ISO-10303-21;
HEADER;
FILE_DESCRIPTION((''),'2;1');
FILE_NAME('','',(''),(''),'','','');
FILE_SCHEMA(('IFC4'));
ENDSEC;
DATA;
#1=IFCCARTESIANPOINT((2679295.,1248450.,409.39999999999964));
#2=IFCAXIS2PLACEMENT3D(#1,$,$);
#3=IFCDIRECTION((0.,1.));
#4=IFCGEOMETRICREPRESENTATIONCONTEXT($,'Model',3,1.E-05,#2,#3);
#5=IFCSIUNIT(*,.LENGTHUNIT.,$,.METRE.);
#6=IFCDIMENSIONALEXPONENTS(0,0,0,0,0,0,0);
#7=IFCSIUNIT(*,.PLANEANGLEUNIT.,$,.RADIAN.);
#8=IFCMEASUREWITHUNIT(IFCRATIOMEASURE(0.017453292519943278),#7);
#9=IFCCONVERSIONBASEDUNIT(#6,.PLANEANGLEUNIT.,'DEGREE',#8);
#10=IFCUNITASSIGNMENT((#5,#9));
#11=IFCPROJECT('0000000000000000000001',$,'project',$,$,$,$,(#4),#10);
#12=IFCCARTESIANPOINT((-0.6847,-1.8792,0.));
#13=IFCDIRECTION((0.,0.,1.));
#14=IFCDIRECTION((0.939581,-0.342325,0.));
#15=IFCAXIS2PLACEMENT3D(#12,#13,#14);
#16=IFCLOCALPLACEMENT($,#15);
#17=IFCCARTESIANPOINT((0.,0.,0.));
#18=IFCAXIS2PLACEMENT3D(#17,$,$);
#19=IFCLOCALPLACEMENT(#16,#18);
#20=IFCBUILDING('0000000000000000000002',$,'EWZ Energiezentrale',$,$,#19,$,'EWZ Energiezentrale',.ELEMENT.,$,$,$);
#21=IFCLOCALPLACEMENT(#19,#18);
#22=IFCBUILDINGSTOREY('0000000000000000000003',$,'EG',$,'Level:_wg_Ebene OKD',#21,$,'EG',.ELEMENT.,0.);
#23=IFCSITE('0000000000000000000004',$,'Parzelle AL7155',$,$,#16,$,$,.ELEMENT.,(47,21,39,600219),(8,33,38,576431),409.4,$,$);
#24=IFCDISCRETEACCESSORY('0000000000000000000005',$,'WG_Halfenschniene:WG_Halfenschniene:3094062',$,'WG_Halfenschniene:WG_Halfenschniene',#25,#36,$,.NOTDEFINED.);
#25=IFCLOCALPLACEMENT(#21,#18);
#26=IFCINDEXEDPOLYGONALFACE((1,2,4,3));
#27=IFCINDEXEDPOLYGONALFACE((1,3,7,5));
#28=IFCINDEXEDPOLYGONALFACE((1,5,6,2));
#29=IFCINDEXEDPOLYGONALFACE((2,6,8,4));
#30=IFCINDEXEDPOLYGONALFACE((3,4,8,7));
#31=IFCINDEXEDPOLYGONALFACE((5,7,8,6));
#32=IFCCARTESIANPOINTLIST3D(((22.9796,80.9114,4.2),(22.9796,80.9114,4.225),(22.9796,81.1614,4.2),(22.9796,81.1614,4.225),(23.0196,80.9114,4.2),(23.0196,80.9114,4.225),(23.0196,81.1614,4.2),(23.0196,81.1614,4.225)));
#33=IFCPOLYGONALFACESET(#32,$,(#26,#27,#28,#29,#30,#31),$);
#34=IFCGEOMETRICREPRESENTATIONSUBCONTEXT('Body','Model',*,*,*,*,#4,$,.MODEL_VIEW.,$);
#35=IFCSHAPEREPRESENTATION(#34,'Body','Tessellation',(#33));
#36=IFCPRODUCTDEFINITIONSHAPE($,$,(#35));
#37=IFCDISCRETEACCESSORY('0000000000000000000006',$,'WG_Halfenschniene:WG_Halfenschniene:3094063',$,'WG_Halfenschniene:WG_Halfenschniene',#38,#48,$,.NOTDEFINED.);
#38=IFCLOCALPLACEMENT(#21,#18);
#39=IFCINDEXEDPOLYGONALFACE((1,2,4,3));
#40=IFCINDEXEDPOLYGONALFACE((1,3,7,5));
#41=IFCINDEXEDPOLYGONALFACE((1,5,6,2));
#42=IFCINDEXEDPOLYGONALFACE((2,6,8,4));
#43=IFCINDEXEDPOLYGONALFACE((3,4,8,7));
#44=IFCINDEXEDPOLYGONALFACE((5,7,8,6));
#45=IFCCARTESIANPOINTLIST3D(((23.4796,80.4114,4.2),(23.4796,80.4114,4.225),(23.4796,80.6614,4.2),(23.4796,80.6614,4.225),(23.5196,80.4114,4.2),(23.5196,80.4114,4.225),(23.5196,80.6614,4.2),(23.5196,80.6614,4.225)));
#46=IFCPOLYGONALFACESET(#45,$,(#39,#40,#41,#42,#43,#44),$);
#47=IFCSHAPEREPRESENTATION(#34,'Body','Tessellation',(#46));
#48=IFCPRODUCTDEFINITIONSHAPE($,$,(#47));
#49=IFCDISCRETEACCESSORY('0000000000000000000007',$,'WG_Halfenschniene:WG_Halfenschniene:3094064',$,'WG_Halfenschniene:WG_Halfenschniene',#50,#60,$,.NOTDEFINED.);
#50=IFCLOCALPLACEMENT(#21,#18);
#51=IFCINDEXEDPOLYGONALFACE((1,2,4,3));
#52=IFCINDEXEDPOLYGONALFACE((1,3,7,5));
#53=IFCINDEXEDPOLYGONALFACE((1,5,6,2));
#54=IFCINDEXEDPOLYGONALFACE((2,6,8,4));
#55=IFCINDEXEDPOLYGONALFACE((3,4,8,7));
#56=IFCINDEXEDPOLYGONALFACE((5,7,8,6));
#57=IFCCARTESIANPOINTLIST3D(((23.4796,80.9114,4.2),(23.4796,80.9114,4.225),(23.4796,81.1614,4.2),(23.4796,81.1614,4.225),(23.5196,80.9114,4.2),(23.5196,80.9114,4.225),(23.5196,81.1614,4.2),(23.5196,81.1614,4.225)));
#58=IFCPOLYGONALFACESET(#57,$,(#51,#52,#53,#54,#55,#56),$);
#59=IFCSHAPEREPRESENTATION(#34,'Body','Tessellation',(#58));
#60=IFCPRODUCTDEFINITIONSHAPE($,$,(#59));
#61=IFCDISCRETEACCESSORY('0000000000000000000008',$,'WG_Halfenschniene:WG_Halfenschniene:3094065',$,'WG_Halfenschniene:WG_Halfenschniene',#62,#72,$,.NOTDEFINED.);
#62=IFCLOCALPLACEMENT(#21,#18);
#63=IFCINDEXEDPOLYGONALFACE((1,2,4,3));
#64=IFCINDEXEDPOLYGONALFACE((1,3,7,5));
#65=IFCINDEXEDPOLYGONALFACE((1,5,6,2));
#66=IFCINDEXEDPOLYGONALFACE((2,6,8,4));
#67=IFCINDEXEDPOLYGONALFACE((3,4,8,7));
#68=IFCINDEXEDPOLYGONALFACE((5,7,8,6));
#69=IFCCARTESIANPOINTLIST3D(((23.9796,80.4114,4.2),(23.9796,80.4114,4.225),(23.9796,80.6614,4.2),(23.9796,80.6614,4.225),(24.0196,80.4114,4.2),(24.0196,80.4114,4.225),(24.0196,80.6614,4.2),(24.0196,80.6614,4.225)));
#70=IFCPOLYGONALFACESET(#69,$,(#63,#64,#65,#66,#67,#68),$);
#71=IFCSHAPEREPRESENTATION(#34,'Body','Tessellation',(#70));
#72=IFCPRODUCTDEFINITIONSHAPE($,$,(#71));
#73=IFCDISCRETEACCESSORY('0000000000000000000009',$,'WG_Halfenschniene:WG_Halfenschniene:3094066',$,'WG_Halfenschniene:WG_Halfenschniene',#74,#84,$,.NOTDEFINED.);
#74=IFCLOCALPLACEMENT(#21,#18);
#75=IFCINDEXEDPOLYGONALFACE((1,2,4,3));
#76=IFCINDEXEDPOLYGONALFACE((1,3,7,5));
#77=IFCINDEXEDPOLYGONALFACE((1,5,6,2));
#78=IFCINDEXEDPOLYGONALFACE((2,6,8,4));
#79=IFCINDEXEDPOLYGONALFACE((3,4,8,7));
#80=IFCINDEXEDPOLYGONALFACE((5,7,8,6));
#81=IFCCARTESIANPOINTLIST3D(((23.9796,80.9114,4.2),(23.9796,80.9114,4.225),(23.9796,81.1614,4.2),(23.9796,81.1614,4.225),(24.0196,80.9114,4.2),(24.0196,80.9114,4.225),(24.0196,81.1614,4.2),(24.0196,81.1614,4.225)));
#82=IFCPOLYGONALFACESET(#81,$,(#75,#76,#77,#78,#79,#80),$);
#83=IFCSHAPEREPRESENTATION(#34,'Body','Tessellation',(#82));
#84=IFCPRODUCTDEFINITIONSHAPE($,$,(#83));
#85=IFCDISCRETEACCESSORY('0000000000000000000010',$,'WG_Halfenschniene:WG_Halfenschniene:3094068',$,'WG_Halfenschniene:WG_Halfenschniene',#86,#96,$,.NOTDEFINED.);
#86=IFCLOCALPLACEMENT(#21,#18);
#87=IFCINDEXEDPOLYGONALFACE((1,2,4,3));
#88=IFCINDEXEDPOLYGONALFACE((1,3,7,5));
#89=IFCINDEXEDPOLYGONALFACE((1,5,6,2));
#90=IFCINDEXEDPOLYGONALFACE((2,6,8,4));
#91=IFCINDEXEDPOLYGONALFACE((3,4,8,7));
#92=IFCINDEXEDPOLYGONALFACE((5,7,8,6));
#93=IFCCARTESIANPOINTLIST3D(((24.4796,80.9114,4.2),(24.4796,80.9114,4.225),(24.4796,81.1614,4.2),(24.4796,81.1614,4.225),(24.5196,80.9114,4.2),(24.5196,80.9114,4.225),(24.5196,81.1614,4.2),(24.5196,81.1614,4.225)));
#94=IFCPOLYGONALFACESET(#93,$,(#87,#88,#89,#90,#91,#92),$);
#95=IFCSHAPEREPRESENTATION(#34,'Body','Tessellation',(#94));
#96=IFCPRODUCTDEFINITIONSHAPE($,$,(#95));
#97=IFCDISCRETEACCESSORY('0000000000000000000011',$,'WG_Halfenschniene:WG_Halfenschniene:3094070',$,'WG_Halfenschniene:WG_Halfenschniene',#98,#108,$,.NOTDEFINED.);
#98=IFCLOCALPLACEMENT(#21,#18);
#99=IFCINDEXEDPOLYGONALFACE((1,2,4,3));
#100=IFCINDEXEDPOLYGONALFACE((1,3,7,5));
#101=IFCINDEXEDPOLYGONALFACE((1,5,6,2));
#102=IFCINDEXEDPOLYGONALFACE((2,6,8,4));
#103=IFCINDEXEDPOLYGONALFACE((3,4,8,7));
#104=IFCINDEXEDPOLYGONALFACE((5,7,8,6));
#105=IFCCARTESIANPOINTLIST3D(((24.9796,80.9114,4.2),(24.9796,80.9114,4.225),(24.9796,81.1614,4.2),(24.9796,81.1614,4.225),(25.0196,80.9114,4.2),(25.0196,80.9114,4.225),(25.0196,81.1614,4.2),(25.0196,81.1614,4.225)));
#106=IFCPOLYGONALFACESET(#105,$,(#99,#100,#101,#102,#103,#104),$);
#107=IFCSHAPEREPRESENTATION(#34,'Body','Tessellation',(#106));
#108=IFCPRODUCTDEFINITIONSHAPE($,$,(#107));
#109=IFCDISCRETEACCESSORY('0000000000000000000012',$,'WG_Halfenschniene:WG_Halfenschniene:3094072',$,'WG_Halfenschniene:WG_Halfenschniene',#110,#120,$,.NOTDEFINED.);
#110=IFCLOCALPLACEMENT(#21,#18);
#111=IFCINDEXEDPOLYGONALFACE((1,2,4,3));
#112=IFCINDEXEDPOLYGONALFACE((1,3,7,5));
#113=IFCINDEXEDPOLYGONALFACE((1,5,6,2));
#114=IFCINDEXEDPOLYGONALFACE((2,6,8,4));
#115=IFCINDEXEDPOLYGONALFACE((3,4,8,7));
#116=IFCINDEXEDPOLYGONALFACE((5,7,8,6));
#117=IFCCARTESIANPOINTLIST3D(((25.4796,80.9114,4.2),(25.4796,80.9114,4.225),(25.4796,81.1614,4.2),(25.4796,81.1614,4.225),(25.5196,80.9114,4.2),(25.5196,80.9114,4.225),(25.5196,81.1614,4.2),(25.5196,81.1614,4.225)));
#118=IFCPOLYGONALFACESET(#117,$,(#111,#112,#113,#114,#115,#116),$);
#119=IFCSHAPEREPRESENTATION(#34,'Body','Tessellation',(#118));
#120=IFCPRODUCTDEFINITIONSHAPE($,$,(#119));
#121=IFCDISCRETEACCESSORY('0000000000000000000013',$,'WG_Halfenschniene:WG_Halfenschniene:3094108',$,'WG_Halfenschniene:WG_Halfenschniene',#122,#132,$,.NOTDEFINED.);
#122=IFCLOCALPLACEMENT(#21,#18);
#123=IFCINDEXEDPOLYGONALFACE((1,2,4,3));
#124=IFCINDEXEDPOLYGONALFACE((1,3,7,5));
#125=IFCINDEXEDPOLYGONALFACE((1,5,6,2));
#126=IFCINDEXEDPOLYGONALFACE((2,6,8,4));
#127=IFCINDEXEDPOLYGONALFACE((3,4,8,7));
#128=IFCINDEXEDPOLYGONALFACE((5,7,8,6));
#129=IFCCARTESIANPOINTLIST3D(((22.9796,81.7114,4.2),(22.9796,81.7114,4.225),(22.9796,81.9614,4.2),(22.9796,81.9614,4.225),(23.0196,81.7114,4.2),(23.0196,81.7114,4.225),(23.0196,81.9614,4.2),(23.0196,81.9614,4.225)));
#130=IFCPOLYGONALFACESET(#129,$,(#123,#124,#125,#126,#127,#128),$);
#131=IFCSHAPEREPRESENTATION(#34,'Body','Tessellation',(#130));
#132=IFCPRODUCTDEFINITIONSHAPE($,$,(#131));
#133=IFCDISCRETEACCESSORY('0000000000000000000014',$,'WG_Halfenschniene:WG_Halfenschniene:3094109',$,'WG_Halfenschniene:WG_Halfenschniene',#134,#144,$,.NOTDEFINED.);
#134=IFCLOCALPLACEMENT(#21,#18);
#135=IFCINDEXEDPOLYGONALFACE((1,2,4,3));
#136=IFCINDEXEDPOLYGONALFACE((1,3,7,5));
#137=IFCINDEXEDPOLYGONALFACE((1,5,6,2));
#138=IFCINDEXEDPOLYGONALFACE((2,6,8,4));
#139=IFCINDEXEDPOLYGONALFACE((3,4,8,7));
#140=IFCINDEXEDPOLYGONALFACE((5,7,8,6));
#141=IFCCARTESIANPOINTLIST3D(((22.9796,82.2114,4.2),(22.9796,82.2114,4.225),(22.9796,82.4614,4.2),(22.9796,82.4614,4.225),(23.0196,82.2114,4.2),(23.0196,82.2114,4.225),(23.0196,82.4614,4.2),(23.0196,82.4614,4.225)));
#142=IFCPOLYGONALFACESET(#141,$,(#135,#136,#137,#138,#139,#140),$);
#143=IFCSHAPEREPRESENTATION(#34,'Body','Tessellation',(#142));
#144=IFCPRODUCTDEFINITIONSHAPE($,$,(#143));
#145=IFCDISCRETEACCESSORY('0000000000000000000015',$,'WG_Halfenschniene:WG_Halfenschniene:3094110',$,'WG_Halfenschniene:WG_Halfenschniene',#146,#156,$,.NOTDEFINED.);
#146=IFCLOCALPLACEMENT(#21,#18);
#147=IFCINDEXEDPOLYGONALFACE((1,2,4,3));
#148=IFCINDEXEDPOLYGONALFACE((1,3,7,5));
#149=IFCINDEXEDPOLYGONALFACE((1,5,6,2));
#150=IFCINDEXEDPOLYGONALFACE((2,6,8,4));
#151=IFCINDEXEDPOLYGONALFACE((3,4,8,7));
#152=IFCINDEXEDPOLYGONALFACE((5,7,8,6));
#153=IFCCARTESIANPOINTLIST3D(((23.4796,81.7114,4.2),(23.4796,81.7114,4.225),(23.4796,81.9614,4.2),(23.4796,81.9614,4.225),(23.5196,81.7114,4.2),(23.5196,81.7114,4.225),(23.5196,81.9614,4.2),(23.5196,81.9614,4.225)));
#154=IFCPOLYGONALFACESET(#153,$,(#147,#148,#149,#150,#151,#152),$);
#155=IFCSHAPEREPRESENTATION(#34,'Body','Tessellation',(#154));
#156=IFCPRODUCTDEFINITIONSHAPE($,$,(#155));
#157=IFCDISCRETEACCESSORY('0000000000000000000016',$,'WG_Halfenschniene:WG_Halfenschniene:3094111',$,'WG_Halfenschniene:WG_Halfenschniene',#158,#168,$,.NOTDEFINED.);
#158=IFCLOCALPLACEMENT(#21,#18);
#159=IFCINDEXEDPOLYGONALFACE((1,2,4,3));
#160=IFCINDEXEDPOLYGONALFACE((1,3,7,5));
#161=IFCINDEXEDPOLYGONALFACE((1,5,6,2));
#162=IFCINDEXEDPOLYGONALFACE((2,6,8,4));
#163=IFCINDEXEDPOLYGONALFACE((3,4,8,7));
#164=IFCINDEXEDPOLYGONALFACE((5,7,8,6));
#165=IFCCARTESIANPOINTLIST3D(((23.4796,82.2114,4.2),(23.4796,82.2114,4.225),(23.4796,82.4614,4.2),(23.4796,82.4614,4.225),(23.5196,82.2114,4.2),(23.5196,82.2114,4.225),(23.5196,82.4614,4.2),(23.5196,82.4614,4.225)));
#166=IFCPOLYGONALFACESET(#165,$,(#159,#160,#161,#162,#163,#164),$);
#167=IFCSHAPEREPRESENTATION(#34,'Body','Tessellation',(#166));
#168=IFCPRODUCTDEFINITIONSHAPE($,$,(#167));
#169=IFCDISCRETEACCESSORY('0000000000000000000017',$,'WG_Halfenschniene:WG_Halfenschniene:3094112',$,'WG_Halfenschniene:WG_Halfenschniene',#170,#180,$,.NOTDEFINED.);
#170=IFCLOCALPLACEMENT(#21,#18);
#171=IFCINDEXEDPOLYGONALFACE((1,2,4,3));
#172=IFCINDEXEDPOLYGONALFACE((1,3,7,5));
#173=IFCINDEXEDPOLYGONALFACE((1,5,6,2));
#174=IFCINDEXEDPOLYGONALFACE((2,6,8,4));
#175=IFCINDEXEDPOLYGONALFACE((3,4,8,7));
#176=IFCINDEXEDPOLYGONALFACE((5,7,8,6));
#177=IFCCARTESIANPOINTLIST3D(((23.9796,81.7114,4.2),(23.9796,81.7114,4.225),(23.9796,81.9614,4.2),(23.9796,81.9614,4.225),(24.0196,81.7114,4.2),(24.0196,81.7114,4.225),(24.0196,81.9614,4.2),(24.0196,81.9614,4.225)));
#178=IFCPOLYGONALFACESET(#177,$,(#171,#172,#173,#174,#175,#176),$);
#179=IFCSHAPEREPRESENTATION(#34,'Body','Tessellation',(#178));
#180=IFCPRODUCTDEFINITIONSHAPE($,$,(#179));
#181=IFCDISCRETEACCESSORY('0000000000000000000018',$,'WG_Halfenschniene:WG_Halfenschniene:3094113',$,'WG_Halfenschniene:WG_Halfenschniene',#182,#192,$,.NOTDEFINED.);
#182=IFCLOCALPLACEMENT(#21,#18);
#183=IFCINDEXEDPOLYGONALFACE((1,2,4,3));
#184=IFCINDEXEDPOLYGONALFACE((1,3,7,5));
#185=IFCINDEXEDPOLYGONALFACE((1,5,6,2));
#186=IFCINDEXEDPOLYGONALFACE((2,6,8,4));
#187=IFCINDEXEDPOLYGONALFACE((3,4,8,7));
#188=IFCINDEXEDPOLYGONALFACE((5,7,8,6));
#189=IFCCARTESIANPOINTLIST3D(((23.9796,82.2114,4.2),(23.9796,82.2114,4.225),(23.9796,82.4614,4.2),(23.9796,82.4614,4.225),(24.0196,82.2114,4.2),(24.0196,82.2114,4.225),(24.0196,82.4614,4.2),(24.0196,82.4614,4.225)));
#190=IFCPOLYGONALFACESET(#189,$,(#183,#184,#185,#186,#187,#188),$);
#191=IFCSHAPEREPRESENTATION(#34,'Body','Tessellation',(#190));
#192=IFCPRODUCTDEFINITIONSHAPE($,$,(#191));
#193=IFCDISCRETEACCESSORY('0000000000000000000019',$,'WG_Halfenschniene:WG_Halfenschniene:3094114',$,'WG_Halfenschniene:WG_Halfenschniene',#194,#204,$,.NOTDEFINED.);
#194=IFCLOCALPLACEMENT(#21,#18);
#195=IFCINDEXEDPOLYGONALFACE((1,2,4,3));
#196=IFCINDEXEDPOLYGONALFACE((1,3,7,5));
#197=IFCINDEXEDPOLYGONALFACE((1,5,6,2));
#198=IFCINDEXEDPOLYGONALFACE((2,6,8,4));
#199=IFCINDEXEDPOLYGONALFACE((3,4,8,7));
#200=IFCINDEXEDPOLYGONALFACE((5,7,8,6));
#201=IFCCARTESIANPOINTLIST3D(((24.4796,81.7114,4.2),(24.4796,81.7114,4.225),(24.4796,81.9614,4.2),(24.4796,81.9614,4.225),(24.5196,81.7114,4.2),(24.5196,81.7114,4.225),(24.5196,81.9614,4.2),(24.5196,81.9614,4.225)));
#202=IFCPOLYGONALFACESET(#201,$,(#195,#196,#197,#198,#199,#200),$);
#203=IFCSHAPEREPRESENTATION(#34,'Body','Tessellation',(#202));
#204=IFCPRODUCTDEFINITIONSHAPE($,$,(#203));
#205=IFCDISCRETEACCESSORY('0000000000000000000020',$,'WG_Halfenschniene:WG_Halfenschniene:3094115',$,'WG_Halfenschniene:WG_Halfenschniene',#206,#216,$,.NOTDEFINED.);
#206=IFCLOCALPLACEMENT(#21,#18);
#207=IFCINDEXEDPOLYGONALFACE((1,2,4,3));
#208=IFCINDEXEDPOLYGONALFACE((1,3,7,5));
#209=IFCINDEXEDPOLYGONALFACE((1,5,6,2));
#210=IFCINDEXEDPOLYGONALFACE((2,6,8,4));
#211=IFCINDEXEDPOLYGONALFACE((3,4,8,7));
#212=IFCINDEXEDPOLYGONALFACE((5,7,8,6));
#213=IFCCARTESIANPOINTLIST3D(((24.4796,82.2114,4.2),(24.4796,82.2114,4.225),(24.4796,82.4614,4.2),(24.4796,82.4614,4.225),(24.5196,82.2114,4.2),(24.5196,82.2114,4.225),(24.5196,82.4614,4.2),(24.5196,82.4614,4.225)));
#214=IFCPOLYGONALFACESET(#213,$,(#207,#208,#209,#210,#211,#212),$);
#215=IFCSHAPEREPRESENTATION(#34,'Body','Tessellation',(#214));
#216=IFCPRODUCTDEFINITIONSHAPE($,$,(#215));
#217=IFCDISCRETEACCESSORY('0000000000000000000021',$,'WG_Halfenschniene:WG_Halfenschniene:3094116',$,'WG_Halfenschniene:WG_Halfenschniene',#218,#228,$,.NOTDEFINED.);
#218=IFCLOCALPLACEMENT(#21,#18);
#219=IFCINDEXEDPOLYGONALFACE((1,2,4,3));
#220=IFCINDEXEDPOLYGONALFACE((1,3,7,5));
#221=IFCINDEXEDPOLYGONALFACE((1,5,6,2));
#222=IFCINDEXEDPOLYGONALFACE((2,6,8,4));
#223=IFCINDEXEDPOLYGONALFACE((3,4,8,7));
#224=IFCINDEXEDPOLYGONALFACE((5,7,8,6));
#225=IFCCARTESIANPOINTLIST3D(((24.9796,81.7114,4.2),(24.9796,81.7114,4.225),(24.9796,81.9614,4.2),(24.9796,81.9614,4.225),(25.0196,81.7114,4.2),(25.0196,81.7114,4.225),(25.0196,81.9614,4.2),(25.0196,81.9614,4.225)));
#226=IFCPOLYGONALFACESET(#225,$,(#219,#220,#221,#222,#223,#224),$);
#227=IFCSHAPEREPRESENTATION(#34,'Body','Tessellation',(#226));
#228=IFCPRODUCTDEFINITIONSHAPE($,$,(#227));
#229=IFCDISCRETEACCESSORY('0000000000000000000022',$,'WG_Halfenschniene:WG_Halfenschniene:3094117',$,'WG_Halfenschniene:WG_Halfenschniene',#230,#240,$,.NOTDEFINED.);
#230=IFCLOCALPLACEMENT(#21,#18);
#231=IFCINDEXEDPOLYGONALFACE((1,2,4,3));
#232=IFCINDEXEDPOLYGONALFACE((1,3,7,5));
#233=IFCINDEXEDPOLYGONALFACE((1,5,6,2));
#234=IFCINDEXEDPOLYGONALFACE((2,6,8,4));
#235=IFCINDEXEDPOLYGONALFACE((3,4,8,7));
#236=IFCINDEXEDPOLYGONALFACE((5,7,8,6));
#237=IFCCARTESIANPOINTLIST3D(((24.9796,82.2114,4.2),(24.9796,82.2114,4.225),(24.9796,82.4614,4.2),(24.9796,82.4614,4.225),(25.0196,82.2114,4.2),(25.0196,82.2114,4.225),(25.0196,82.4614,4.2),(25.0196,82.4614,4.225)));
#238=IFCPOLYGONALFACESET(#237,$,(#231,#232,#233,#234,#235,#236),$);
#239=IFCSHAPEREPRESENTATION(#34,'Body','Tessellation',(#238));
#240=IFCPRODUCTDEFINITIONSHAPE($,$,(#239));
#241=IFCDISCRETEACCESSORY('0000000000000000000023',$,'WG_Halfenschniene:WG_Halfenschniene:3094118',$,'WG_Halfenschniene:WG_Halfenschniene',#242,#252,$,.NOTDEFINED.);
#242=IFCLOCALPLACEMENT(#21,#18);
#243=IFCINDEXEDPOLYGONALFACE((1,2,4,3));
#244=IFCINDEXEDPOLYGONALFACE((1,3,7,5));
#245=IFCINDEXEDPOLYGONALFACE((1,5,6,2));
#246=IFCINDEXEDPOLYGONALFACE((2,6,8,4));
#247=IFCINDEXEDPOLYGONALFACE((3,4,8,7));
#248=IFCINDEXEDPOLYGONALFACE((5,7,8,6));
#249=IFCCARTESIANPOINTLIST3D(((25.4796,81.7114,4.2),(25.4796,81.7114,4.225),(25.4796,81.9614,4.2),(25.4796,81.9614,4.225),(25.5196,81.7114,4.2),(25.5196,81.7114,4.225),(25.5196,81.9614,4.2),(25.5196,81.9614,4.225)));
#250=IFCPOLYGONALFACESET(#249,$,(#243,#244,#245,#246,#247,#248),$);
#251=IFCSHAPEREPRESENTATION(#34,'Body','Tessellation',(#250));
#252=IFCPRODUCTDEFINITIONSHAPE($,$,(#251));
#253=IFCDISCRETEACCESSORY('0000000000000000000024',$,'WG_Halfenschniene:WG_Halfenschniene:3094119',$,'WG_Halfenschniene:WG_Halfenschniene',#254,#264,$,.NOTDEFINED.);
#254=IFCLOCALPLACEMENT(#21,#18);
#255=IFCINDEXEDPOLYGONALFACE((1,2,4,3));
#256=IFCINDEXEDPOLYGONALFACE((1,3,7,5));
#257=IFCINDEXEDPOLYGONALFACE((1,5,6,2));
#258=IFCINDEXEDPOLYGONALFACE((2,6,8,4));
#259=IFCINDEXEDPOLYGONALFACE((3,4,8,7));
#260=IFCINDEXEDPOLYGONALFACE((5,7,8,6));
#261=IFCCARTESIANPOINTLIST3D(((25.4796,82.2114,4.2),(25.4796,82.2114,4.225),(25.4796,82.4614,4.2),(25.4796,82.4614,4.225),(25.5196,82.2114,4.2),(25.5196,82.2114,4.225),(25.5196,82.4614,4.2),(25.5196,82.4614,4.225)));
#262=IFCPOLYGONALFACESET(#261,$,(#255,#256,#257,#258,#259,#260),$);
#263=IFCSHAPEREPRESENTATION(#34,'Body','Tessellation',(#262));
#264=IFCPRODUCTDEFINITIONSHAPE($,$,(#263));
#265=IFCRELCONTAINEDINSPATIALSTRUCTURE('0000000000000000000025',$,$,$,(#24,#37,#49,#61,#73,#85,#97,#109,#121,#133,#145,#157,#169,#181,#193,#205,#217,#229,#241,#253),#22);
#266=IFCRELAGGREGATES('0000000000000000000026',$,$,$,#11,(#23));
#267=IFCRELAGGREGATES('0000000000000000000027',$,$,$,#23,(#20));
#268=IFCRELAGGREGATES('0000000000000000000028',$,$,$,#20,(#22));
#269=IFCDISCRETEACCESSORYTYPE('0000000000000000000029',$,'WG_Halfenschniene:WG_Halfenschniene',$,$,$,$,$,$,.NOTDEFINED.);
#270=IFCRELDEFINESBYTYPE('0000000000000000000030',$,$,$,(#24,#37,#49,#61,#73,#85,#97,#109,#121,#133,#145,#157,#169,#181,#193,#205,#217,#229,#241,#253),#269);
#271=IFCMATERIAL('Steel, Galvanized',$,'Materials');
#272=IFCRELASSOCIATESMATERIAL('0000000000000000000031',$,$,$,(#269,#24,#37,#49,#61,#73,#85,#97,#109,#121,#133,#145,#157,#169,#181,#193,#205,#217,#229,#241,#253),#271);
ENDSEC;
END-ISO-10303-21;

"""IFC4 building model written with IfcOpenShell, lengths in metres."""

from ifc_helpers import new_model, entity, si_unit, converted_unit, direction, frame, origin, place, context, subcontext, project, spatial, indexed_curve, outline, extrude, source, transform, mapped, material, type_object, element, save


model = new_model("IFC4")

# Units and contexts
model_context = context("Model", 3, precision=1e-05, world=frame((2679295.0, 1248450.0, 409.39999999999964)), true_north=direction((0.0, 1.0)))
body_context = subcontext(model_context, "Body", "Model", "MODEL_VIEW")
ifc_project = project(units=[si_unit("LENGTHUNIT", "METRE"), converted_unit("PLANEANGLEUNIT", "DEGREE", entity("IfcRatioMeasure", 0.017453292519943278), si_unit("PLANEANGLEUNIT", "RADIAN"), dimensions=[0, 0, 0, 0, 0, 0, 0])], contexts=[model_context])

# Site, building, storey
site_placement = place(None, frame((-0.6847, -1.8792, 0.0), z_axis=(0.0, 0.0, 1.0), x_axis=(0.939581, -0.342325, 0.0)))
site = spatial("IfcSite", under=ifc_project, at=site_placement, Name="Parzelle AL7155", CompositionType="ELEMENT", RefLatitude=(47, 21, 39, 600219), RefLongitude=(8, 33, 38, 576431), RefElevation=409.4)
building_placement = place(site_placement, origin())
building = spatial("IfcBuilding", under=site, at=building_placement, Name="EWZ Energiezentrale", LongName="EWZ Energiezentrale", CompositionType="ELEMENT")
storey_placement = place(building_placement, origin())
storey = spatial("IfcBuildingStorey", under=building, at=storey_placement, Name="EG", ObjectType="Level:_wg_Ebene OKD", LongName="EG", CompositionType="ELEMENT", Elevation=0.0)

# Discrete accessories
ifc_material = material(Name="Steel, Galvanized", Category="Materials")
discrete_accessory_type = type_object("IfcDiscreteAccessoryType", Name="WG_Halfenschniene:WG_Halfenschniene", PredefinedType="NOTDEFINED", material=ifc_material)
shared_shape = source(origin(), body_context, "Body", "SweptSolid", [
    extrude(outline(indexed_curve([(-0.125, -0.02), (0.125, -0.02), (0.125, 0.02), (-0.125, 0.02), (-0.125, -0.02)], self_intersect=False)), frame((0.125, 0.0, -0.0125)), (0.0, 0.0, 1.0), 0.025),
])
for number, where, z_axis, x_axis, name in (
    (1, (22.9996, 80.9114, 4.2125), (0.0, 0.0, -1.0), (0.0, 1.0, 0.0), "WG_Halfenschniene:WG_Halfenschniene:3094062"),
    (2, (23.4996, 80.4114, 4.2125), (0.0, 0.0, -1.0), (0.0, 1.0, 0.0), "WG_Halfenschniene:WG_Halfenschniene:3094063"),
    (3, (23.4996, 80.9114, 4.2125), (0.0, 0.0, -1.0), (0.0, 1.0, 0.0), "WG_Halfenschniene:WG_Halfenschniene:3094064"),
    (4, (23.9996, 80.4114, 4.2125), (0.0, 0.0, -1.0), (0.0, 1.0, 0.0), "WG_Halfenschniene:WG_Halfenschniene:3094065"),
    (5, (23.9996, 80.9114, 4.2125), (0.0, 0.0, -1.0), (0.0, 1.0, 0.0), "WG_Halfenschniene:WG_Halfenschniene:3094066"),
    (6, (24.4996, 80.9114, 4.2125), (0.0, 0.0, -1.0), (0.0, 1.0, 0.0), "WG_Halfenschniene:WG_Halfenschniene:3094068"),
    (7, (24.9996, 80.9114, 4.2125), (0.0, 0.0, -1.0), (0.0, 1.0, 0.0), "WG_Halfenschniene:WG_Halfenschniene:3094070"),
    (8, (25.4996, 80.9114, 4.2125), (0.0, 0.0, -1.0), (0.0, 1.0, 0.0), "WG_Halfenschniene:WG_Halfenschniene:3094072"),
    (9, (22.9996, 81.7114, 4.2125), (0.0, 0.0, -1.0), (0.0, 1.0, 0.0), "WG_Halfenschniene:WG_Halfenschniene:3094108"),
    (10, (22.9996, 82.2114, 4.2125), (0.0, 0.0, -1.0), (0.0, 1.0, 0.0), "WG_Halfenschniene:WG_Halfenschniene:3094109"),
    (11, (23.4996, 81.7114, 4.2125), (0.0, 0.0, -1.0), (0.0, 1.0, 0.0), "WG_Halfenschniene:WG_Halfenschniene:3094110"),
    (12, (23.4996, 82.2114, 4.2125), (0.0, 0.0, -1.0), (0.0, 1.0, 0.0), "WG_Halfenschniene:WG_Halfenschniene:3094111"),
    (13, (23.9996, 81.7114, 4.2125), (0.0, 0.0, -1.0), (0.0, 1.0, 0.0), "WG_Halfenschniene:WG_Halfenschniene:3094112"),
    (14, (23.9996, 82.2114, 4.2125), (0.0, 0.0, -1.0), (0.0, 1.0, 0.0), "WG_Halfenschniene:WG_Halfenschniene:3094113"),
    (15, (24.4996, 81.7114, 4.2125), (0.0, 0.0, -1.0), (0.0, 1.0, 0.0), "WG_Halfenschniene:WG_Halfenschniene:3094114"),
    (16, (24.4996, 82.2114, 4.2125), (0.0, 0.0, -1.0), (0.0, 1.0, 0.0), "WG_Halfenschniene:WG_Halfenschniene:3094115"),
    (17, (24.9996, 81.7114, 4.2125), (0.0, 0.0, -1.0), (0.0, 1.0, 0.0), "WG_Halfenschniene:WG_Halfenschniene:3094116"),
    (18, (24.9996, 82.2114, 4.2125), (0.0, 0.0, -1.0), (0.0, 1.0, 0.0), "WG_Halfenschniene:WG_Halfenschniene:3094117"),
    (19, (25.4996, 81.7114, 4.2125), (0.0, 0.0, -1.0), (0.0, 1.0, 0.0), "WG_Halfenschniene:WG_Halfenschniene:3094118"),
    (20, (25.4996, 82.2114, 4.2125), (0.0, 0.0, -1.0), (0.0, 1.0, 0.0), "WG_Halfenschniene:WG_Halfenschniene:3094119"),
):
    element("IfcDiscreteAccessory", number, at=place(storey_placement, frame(where, z_axis=z_axis, x_axis=x_axis)), inside=storey, type_object=discrete_accessory_type, material=ifc_material, Name=name, ObjectType="WG_Halfenschniene:WG_Halfenschniene", PredefinedType="NOTDEFINED", context=body_context, shape_type="MappedRepresentation", body=[
        mapped(shared_shape, transform((0.0, 0.0, 0.0), scale=1.0)),
    ])

save(model, "model.ifc")
